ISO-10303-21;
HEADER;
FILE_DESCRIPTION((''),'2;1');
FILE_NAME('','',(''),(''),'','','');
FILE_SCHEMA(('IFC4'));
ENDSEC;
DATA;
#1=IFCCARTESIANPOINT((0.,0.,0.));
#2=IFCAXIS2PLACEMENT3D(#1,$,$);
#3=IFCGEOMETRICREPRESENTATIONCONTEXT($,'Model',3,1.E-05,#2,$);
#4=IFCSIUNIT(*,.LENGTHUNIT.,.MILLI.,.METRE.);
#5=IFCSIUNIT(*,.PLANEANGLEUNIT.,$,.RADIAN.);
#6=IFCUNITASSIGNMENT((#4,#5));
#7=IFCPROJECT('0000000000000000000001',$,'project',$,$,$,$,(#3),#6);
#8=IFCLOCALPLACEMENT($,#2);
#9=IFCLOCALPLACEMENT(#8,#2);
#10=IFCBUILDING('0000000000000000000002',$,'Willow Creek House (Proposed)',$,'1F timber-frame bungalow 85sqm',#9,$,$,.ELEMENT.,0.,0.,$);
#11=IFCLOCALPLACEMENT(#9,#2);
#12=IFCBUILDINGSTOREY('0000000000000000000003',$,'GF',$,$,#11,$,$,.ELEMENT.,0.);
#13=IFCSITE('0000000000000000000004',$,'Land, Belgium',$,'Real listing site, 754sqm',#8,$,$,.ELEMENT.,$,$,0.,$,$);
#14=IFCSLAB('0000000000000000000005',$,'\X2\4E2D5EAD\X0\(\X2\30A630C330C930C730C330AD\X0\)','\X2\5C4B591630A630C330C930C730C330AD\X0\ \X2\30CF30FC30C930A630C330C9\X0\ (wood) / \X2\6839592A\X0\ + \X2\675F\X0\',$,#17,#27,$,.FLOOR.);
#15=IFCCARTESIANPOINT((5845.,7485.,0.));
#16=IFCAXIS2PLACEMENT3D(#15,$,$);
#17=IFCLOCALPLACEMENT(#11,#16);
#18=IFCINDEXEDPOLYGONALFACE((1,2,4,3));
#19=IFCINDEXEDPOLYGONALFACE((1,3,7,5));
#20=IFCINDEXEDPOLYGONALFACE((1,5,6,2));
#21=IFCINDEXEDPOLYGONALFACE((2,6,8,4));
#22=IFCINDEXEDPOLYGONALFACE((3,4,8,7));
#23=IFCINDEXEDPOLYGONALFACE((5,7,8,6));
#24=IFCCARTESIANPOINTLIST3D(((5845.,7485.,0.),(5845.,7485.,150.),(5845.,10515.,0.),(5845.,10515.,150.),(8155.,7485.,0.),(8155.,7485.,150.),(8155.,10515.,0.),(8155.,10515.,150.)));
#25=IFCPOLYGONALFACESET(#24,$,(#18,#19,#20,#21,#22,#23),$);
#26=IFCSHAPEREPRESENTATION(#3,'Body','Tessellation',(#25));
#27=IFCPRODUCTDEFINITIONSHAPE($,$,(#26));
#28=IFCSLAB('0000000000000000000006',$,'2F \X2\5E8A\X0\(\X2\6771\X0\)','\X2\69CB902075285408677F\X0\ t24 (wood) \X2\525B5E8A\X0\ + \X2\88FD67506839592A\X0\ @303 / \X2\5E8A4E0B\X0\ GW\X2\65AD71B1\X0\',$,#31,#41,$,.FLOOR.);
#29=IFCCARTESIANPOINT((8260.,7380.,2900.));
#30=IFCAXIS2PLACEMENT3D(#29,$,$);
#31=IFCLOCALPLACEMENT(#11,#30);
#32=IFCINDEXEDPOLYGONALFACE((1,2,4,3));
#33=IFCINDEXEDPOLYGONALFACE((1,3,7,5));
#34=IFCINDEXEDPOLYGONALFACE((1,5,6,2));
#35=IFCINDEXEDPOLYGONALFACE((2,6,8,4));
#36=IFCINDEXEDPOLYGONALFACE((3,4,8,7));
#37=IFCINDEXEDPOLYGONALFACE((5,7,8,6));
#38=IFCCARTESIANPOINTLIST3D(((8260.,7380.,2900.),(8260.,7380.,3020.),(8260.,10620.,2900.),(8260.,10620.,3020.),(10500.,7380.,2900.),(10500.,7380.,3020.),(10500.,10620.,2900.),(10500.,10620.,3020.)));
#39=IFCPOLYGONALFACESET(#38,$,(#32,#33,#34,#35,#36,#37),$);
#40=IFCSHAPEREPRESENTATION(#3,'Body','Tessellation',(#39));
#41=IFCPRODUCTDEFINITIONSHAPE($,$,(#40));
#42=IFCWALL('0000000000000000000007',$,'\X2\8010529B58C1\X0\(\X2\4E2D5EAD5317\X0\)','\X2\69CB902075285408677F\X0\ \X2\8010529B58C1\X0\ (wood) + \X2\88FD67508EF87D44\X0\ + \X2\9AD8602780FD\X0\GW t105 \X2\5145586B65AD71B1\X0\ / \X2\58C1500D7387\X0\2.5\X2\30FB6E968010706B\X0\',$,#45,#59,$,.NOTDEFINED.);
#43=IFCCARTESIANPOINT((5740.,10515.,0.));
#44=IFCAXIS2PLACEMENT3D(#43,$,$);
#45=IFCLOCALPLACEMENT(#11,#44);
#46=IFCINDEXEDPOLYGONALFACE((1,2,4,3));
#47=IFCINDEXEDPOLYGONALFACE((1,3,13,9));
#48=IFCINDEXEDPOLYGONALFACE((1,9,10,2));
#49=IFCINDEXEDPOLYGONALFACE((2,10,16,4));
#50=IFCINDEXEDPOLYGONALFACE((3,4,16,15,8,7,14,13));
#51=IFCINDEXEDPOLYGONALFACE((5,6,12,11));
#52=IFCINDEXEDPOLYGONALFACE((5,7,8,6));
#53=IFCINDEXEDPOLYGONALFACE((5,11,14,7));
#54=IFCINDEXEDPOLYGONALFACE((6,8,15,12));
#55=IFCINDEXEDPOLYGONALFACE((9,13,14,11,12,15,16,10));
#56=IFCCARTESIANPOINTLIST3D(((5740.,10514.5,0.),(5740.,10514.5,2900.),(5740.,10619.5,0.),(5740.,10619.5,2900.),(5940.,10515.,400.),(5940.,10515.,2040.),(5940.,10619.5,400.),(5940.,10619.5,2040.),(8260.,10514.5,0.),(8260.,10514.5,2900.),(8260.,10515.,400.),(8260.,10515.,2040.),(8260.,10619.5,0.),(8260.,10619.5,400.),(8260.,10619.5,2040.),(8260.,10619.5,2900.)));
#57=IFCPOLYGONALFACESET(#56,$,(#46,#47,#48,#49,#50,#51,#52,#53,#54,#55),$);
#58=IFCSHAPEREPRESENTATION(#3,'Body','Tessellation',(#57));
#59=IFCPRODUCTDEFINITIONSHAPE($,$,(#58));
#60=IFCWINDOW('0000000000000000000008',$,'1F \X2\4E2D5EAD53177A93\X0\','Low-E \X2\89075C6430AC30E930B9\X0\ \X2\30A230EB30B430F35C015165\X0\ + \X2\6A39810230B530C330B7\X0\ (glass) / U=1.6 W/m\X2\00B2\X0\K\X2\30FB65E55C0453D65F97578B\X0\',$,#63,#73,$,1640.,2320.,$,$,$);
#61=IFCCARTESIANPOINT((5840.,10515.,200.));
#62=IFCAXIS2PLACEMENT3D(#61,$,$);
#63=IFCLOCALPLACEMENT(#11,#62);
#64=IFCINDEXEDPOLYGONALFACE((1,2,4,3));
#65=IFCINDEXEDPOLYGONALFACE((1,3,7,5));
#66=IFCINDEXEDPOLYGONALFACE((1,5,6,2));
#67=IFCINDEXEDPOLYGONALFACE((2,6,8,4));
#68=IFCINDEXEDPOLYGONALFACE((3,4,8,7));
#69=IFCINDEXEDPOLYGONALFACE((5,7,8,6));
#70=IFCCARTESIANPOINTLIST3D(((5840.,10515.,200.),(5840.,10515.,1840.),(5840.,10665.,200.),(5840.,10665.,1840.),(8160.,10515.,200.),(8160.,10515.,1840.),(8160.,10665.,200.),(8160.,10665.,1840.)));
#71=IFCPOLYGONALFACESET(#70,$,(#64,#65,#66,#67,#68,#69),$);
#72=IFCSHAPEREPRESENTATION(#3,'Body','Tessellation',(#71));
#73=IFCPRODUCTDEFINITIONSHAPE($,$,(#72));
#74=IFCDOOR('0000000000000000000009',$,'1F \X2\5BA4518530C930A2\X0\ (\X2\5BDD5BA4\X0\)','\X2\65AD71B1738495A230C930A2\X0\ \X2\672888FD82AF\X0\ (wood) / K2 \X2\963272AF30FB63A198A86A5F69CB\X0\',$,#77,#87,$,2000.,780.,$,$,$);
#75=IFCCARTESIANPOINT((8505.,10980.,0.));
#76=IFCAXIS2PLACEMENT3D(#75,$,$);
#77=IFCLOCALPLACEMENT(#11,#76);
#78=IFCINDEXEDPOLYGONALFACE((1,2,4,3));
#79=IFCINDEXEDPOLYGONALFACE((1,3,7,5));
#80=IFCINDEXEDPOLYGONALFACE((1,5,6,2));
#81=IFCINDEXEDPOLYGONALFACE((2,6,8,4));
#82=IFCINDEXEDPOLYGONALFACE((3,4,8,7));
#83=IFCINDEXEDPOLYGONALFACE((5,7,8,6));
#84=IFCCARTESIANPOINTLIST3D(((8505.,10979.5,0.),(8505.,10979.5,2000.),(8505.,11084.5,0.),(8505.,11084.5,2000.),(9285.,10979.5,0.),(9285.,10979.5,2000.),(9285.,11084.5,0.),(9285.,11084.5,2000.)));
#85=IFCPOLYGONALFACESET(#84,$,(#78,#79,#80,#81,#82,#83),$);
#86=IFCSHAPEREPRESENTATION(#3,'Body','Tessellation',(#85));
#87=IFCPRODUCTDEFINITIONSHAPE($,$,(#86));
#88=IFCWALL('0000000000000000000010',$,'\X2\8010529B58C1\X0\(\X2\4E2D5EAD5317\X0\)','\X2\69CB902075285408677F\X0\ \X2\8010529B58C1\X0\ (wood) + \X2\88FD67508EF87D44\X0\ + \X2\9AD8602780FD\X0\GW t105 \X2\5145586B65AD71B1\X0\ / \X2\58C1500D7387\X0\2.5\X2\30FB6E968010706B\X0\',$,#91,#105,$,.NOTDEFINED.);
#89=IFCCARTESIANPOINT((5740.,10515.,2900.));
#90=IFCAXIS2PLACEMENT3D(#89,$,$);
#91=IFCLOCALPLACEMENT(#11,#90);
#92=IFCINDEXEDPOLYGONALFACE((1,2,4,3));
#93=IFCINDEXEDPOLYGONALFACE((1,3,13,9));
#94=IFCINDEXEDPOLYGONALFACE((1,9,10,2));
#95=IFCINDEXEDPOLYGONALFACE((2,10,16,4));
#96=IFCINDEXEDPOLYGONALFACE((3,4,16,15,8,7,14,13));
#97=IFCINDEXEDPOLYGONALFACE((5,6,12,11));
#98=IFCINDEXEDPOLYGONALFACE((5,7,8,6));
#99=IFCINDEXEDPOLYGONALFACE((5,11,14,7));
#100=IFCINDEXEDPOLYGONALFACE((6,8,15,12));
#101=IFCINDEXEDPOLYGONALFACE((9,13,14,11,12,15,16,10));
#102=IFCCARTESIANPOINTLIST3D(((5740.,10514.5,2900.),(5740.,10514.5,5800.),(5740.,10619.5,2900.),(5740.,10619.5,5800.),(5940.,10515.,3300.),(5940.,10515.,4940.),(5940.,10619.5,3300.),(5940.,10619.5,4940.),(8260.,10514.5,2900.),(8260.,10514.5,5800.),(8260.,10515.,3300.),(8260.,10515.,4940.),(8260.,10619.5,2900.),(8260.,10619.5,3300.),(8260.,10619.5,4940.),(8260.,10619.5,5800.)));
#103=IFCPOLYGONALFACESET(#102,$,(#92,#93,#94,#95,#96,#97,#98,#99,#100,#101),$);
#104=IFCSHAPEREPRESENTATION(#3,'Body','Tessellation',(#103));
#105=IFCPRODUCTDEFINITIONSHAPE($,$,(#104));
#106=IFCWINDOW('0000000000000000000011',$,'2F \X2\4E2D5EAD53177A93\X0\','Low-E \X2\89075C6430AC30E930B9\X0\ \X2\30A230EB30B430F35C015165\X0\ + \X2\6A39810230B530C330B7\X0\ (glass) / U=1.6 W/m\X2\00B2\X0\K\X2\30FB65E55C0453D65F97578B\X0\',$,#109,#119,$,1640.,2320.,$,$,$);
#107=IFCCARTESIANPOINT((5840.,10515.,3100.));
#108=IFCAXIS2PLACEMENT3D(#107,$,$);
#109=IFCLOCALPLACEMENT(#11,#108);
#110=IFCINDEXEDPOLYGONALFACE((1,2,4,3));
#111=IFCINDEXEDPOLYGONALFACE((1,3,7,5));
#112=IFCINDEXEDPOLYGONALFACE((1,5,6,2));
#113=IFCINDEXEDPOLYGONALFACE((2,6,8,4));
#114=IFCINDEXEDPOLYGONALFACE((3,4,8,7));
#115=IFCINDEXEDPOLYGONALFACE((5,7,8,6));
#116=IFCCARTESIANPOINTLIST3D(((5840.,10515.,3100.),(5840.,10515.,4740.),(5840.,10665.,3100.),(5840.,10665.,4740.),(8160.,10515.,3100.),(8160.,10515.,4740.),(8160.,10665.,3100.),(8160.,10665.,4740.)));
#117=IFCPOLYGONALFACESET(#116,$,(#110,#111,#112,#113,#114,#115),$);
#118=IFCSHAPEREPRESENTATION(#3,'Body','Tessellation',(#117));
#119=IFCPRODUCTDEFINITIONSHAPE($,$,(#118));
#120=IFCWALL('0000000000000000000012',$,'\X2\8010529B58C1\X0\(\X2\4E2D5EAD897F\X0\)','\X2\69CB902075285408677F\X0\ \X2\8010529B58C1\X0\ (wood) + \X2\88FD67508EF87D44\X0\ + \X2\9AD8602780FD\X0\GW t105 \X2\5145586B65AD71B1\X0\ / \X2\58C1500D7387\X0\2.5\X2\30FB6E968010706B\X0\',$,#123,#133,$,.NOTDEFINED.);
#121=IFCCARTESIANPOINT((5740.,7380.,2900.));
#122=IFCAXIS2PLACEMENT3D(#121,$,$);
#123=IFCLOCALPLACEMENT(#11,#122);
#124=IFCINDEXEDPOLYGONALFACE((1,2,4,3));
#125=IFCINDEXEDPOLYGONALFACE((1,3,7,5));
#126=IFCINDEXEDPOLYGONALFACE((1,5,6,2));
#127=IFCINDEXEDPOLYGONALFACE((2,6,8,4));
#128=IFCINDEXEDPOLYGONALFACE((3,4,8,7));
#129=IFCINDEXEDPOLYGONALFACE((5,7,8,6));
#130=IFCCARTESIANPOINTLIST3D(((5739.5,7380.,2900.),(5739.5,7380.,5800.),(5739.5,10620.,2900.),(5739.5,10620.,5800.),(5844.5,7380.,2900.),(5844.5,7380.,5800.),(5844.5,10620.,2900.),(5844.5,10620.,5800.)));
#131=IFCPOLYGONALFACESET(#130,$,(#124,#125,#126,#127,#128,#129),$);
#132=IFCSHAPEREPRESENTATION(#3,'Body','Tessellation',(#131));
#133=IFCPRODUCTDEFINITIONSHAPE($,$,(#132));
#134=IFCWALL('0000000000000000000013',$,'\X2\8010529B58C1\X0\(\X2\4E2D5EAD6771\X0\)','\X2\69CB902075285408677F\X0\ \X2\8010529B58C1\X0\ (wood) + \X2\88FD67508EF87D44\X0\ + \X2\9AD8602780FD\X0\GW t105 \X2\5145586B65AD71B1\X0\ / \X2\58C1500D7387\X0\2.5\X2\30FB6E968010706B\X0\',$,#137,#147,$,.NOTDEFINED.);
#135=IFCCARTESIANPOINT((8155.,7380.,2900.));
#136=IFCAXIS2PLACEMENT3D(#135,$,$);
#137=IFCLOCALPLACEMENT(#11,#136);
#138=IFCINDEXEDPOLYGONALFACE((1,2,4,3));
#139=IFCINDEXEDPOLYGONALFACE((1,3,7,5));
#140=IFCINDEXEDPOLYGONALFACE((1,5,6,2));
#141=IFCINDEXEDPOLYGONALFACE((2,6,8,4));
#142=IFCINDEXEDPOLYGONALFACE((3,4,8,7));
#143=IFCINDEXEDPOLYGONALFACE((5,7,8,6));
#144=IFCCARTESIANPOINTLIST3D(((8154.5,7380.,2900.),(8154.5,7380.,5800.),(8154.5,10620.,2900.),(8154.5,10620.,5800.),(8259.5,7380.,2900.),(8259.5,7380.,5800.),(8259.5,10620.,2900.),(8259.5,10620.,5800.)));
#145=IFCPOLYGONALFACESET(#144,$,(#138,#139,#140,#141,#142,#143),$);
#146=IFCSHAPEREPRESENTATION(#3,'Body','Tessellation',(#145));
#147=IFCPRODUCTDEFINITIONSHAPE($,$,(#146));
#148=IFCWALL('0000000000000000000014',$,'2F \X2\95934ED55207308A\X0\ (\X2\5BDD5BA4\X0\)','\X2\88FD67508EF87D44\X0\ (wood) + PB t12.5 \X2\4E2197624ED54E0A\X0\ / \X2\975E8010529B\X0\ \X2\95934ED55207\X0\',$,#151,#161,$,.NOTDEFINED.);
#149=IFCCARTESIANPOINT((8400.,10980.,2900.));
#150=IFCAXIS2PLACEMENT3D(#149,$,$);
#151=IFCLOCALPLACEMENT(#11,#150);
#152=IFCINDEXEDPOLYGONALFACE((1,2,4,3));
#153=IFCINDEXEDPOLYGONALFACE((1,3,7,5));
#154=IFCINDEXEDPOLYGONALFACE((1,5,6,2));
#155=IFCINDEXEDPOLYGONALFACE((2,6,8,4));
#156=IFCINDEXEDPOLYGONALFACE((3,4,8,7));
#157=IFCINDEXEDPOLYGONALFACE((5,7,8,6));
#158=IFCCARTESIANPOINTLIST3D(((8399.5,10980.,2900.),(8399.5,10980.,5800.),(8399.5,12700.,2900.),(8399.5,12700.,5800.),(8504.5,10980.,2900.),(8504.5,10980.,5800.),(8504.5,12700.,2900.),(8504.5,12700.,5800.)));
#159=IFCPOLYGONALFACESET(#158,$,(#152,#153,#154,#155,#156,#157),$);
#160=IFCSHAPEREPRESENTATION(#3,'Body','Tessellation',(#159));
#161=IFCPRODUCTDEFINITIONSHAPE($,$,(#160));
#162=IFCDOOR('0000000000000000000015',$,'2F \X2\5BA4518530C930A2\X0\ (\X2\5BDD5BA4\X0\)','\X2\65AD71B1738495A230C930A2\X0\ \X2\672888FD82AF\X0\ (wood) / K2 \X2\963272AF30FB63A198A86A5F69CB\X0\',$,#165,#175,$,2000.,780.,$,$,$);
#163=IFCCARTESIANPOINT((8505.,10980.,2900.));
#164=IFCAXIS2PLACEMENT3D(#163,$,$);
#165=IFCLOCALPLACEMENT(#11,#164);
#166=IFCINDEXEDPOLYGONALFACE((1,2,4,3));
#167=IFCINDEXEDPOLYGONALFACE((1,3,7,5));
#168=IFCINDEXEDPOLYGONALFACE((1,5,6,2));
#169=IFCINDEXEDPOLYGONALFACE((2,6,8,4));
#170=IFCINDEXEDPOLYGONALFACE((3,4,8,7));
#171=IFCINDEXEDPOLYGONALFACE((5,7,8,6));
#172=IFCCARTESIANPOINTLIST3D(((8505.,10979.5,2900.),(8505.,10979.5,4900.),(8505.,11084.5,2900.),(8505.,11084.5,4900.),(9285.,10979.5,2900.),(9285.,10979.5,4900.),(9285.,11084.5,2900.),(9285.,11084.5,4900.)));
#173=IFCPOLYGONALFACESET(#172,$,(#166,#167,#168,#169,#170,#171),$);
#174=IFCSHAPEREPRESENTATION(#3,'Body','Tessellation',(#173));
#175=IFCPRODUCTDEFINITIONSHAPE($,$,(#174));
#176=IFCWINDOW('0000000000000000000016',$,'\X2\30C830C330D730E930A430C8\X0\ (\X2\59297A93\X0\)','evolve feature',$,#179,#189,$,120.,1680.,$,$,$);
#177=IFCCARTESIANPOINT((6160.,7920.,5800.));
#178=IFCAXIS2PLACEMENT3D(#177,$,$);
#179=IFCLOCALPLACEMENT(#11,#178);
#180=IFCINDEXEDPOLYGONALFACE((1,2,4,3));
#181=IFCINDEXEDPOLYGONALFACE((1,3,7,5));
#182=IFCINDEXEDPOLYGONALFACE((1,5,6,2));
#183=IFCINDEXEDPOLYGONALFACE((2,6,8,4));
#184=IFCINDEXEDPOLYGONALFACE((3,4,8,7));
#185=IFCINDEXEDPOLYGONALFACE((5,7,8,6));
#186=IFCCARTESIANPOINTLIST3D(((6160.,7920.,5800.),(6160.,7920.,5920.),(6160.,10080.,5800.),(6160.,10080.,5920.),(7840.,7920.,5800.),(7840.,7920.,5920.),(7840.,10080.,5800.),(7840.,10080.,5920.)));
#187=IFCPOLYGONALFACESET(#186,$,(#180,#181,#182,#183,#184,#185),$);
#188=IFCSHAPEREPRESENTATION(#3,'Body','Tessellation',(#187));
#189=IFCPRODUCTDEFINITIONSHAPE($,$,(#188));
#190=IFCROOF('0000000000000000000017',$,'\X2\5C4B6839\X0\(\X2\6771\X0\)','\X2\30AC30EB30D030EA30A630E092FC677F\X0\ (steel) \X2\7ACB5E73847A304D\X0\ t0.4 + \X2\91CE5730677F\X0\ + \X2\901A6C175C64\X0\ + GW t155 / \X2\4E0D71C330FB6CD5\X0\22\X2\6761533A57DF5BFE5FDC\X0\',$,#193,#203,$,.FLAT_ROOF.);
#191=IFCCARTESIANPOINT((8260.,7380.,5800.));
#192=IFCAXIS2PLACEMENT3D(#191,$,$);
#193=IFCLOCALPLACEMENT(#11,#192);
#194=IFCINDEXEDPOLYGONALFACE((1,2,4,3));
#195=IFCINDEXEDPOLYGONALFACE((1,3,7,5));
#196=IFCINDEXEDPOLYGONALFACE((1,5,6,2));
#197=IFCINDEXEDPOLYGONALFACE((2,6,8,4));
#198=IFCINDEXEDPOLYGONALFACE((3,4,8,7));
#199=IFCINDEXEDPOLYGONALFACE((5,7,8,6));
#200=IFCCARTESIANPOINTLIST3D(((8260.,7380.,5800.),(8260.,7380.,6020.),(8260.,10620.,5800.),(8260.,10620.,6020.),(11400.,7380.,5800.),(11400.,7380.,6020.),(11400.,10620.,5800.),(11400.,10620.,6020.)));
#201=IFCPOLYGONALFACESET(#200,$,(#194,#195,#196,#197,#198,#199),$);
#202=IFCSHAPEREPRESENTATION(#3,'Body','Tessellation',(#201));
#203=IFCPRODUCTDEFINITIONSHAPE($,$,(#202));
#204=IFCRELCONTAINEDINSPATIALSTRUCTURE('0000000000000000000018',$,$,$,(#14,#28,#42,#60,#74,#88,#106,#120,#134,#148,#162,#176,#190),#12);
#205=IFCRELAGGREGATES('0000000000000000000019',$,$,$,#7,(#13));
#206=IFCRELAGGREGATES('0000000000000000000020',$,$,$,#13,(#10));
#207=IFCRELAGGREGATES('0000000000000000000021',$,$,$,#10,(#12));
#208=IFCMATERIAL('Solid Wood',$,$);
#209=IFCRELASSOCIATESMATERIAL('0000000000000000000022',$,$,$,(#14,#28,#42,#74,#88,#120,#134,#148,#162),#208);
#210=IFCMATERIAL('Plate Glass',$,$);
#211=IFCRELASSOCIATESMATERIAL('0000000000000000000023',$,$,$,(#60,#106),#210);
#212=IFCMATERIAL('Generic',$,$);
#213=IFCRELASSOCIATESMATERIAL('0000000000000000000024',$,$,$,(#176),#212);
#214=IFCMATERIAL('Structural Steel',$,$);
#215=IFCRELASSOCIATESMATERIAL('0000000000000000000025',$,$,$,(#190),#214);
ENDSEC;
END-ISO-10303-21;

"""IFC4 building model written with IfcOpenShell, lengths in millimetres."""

from ifc_helpers import new_model, si_unit, frame, frame_2d, origin, place, context, project, spatial, rectangle, extrude, material, element, fill, save


model = new_model("IFC4")

# Units and contexts
model_context = context("Model", 3, precision=1e-05, world=origin())
ifc_project = project(units=[si_unit("LENGTHUNIT", "METRE", prefix="MILLI"), si_unit("PLANEANGLEUNIT", "RADIAN")], contexts=[model_context])

# Site, building, storey
site_placement = place(None, origin())
site = spatial("IfcSite", under=ifc_project, at=site_placement, Name="Land, Belgium", ObjectType="Real listing site, 754sqm", CompositionType="ELEMENT", RefElevation=0.0)
building_placement = place(site_placement, origin())
building = spatial("IfcBuilding", under=site, at=building_placement, Name="Willow Creek House (Proposed)", ObjectType="1F timber-frame bungalow 85sqm", CompositionType="ELEMENT", ElevationOfRefHeight=0.0, ElevationOfTerrain=0.0)
storey_placement = place(building_placement, origin())
storey = spatial("IfcBuildingStorey", under=building, at=storey_placement, Name="GF", CompositionType="ELEMENT", Elevation=0.0)

# Slabs
ifc_material_1 = material(Name="Solid Wood")
slab_1_placement = place(storey_placement, frame((5845.0, 7485.0, 0.0)))
element("IfcSlab", 1, at=slab_1_placement, inside=storey, material=ifc_material_1, Name="中庭(ウッドデッキ)", Description="屋外ウッドデッキ ハードウッド (wood) / 根太 + 束", PredefinedType="FLOOR", context=model_context, shape_type="SweptSolid", body=[
    extrude(rectangle(XDim=2310.0, YDim=3030.0, at=frame_2d((1155.0, 1515.0))), frame((5845.0, 7485.0, 0.0)), (0.0, 0.0, 1.0), 150.0),
])
slab_2_placement = place(storey_placement, frame((8260.0, 7380.0, 2900.0)))
element("IfcSlab", 2, at=slab_2_placement, inside=storey, material=ifc_material_1, Name="2F 床(東)", Description="構造用合板 t24 (wood) 剛床 + 製材根太 @303 / 床下 GW断熱", PredefinedType="FLOOR", context=model_context, shape_type="SweptSolid", body=[
    extrude(rectangle(XDim=2240.0, YDim=3240.0, at=frame_2d((1120.0, 1620.0))), frame((8260.0, 7380.0, 2900.0)), (0.0, 0.0, 1.0), 120.0),
])

# Wall, opening, window
wall_1_placement = place(storey_placement, frame((5740.0, 10515.0, 0.0)))
wall_1 = element("IfcWall", 3, at=wall_1_placement, inside=storey, material=ifc_material_1, Name="耐力壁(中庭北)", Description="構造用合板 耐力壁 (wood) + 製材軸組 + 高性能GW t105 充填断熱 / 壁倍率2.5・準耐火", PredefinedType="NOTDEFINED", context=model_context, shape_type="SweptSolid", body=[
    extrude(rectangle(XDim=2520.0, YDim=105.0, at=frame_2d((1260.0, 52.0))), frame((5740.0, 10515.0, 0.0)), (0.0, 0.0, 1.0), 2900.0),
])
opening_1_placement = place(storey_placement, frame((5840.0, 10515.0, 200.0)))
opening_1 = element("IfcOpeningElement", 4, at=opening_1_placement, cuts=wall_1, PredefinedType="NOTDEFINED", context=model_context, shape_type="SweptSolid", body=[
    extrude(rectangle(XDim=2320.0, YDim=150.0, at=frame_2d((1160.0, 75.0))), frame((5840.0, 10515.0, 200.0)), (0.0, 0.0, 1.0), 1640.0),
])
ifc_material_2 = material(Name="Plate Glass")
window_1_placement = place(storey_placement, frame((5840.0, 10515.0, 200.0)))
window_1 = element("IfcWindow", 5, at=window_1_placement, inside=storey, material=ifc_material_2, Name="1F 中庭北窓", Description="Low-E 複層ガラス アルゴン封入 + 樹脂サッシ (glass) / U=1.6 W/m²K・日射取得型", OverallHeight=1640.0, OverallWidth=2320.0, context=model_context, shape_type="SweptSolid", body=[
    extrude(rectangle(XDim=2320.0, YDim=150.0, at=frame_2d((1160.0, 75.0))), frame((5840.0, 10515.0, 200.0)), (0.0, 0.0, 1.0), 1640.0),
])
fill(opening_1, window_1)

# Door
door_1_placement = place(storey_placement, frame((8505.0, 10980.0, 0.0)))
element("IfcDoor", 6, at=door_1_placement, inside=storey, material=ifc_material_1, Name="1F 室内ドア (寝室)", Description="断熱玄関ドア 木製芯 (wood) / K2 防犯・採風機構", OverallHeight=2000.0, OverallWidth=780.0, context=model_context, shape_type="SweptSolid", body=[
    extrude(rectangle(XDim=780.0, YDim=105.0, at=frame_2d((390.0, 52.0))), frame((8505.0, 10980.0, 0.0)), (0.0, 0.0, 1.0), 2000.0),
])

# Wall, opening, window
wall_2_placement = place(storey_placement, frame((5740.0, 10515.0, 2900.0)))
wall_2 = element("IfcWall", 7, at=wall_2_placement, inside=storey, material=ifc_material_1, Name="耐力壁(中庭北)", Description="構造用合板 耐力壁 (wood) + 製材軸組 + 高性能GW t105 充填断熱 / 壁倍率2.5・準耐火", PredefinedType="NOTDEFINED", context=model_context, shape_type="SweptSolid", body=[
    extrude(rectangle(XDim=2520.0, YDim=105.0, at=frame_2d((1260.0, 52.0))), frame((5740.0, 10515.0, 2900.0)), (0.0, 0.0, 1.0), 2900.0),
])
opening_2_placement = place(storey_placement, frame((5840.0, 10515.0, 3100.0)))
opening_2 = element("IfcOpeningElement", 8, at=opening_2_placement, cuts=wall_2, PredefinedType="NOTDEFINED", context=model_context, shape_type="SweptSolid", body=[
    extrude(rectangle(XDim=2320.0, YDim=150.0, at=frame_2d((1160.0, 75.0))), frame((5840.0, 10515.0, 3100.0)), (0.0, 0.0, 1.0), 1640.0),
])
window_2_placement = place(storey_placement, frame((5840.0, 10515.0, 3100.0)))
window_2 = element("IfcWindow", 9, at=window_2_placement, inside=storey, material=ifc_material_2, Name="2F 中庭北窓", Description="Low-E 複層ガラス アルゴン封入 + 樹脂サッシ (glass) / U=1.6 W/m²K・日射取得型", OverallHeight=1640.0, OverallWidth=2320.0, context=model_context, shape_type="SweptSolid", body=[
    extrude(rectangle(XDim=2320.0, YDim=150.0, at=frame_2d((1160.0, 75.0))), frame((5840.0, 10515.0, 3100.0)), (0.0, 0.0, 1.0), 1640.0),
])
fill(opening_2, window_2)

# Walls
wall_3_placement = place(storey_placement, frame((5740.0, 7380.0, 2900.0)))
element("IfcWall", 10, at=wall_3_placement, inside=storey, material=ifc_material_1, Name="耐力壁(中庭西)", Description="構造用合板 耐力壁 (wood) + 製材軸組 + 高性能GW t105 充填断熱 / 壁倍率2.5・準耐火", PredefinedType="NOTDEFINED", context=model_context, shape_type="SweptSolid", body=[
    extrude(rectangle(XDim=105.0, YDim=3240.0, at=frame_2d((52.0, 1620.0))), frame((5740.0, 7380.0, 2900.0)), (0.0, 0.0, 1.0), 2900.0),
])
wall_4_placement = place(storey_placement, frame((8155.0, 7380.0, 2900.0)))
element("IfcWall", 11, at=wall_4_placement, inside=storey, material=ifc_material_1, Name="耐力壁(中庭東)", Description="構造用合板 耐力壁 (wood) + 製材軸組 + 高性能GW t105 充填断熱 / 壁倍率2.5・準耐火", PredefinedType="NOTDEFINED", context=model_context, shape_type="SweptSolid", body=[
    extrude(rectangle(XDim=105.0, YDim=3240.0, at=frame_2d((52.0, 1620.0))), frame((8155.0, 7380.0, 2900.0)), (0.0, 0.0, 1.0), 2900.0),
])
wall_5_placement = place(storey_placement, frame((8400.0, 10980.0, 2900.0)))
element("IfcWall", 12, at=wall_5_placement, inside=storey, material=ifc_material_1, Name="2F 間仕切り (寝室)", Description="製材軸組 (wood) + PB t12.5 両面仕上 / 非耐力 間仕切", PredefinedType="NOTDEFINED", context=model_context, shape_type="SweptSolid", body=[
    extrude(rectangle(XDim=105.0, YDim=1720.0, at=frame_2d((52.0, 860.0))), frame((8400.0, 10980.0, 2900.0)), (0.0, 0.0, 1.0), 2900.0),
])

# Door
door_2_placement = place(storey_placement, frame((8505.0, 10980.0, 2900.0)))
element("IfcDoor", 13, at=door_2_placement, inside=storey, material=ifc_material_1, Name="2F 室内ドア (寝室)", Description="断熱玄関ドア 木製芯 (wood) / K2 防犯・採風機構", OverallHeight=2000.0, OverallWidth=780.0, context=model_context, shape_type="SweptSolid", body=[
    extrude(rectangle(XDim=780.0, YDim=105.0, at=frame_2d((390.0, 52.0))), frame((8505.0, 10980.0, 2900.0)), (0.0, 0.0, 1.0), 2000.0),
])

# Window
ifc_material_3 = material(Name="Generic")
window_3_placement = place(storey_placement, frame((6160.0, 7920.0, 5800.0)))
element("IfcWindow", 14, at=window_3_placement, inside=storey, material=ifc_material_3, Name="トップライト (天窓)", Description="evolve feature", OverallHeight=120.0, OverallWidth=1680.0, context=model_context, shape_type="SweptSolid", body=[
    extrude(rectangle(XDim=1680.0, YDim=2160.0, at=frame_2d((840.0, 1080.0))), frame((6160.0, 7920.0, 5800.0)), (0.0, 0.0, 1.0), 120.0),
])

# Roof
ifc_material_4 = material(Name="Structural Steel")
roof_placement = place(storey_placement, frame((8260.0, 7380.0, 5800.0)))
element("IfcRoof", 15, at=roof_placement, inside=storey, material=ifc_material_4, Name="屋根(東)", Description="ガルバリウム鋼板 (steel) 立平葺き t0.4 + 野地板 + 通気層 + GW t155 / 不燃・法22条区域対応", PredefinedType="FLAT_ROOF", context=model_context, shape_type="SweptSolid", body=[
    extrude(rectangle(XDim=3140.0, YDim=3240.0, at=frame_2d((1570.0, 1620.0))), frame((8260.0, 7380.0, 5800.0)), (0.0, 0.0, 1.0), 220.0),
])

save(model, "model.ifc")
